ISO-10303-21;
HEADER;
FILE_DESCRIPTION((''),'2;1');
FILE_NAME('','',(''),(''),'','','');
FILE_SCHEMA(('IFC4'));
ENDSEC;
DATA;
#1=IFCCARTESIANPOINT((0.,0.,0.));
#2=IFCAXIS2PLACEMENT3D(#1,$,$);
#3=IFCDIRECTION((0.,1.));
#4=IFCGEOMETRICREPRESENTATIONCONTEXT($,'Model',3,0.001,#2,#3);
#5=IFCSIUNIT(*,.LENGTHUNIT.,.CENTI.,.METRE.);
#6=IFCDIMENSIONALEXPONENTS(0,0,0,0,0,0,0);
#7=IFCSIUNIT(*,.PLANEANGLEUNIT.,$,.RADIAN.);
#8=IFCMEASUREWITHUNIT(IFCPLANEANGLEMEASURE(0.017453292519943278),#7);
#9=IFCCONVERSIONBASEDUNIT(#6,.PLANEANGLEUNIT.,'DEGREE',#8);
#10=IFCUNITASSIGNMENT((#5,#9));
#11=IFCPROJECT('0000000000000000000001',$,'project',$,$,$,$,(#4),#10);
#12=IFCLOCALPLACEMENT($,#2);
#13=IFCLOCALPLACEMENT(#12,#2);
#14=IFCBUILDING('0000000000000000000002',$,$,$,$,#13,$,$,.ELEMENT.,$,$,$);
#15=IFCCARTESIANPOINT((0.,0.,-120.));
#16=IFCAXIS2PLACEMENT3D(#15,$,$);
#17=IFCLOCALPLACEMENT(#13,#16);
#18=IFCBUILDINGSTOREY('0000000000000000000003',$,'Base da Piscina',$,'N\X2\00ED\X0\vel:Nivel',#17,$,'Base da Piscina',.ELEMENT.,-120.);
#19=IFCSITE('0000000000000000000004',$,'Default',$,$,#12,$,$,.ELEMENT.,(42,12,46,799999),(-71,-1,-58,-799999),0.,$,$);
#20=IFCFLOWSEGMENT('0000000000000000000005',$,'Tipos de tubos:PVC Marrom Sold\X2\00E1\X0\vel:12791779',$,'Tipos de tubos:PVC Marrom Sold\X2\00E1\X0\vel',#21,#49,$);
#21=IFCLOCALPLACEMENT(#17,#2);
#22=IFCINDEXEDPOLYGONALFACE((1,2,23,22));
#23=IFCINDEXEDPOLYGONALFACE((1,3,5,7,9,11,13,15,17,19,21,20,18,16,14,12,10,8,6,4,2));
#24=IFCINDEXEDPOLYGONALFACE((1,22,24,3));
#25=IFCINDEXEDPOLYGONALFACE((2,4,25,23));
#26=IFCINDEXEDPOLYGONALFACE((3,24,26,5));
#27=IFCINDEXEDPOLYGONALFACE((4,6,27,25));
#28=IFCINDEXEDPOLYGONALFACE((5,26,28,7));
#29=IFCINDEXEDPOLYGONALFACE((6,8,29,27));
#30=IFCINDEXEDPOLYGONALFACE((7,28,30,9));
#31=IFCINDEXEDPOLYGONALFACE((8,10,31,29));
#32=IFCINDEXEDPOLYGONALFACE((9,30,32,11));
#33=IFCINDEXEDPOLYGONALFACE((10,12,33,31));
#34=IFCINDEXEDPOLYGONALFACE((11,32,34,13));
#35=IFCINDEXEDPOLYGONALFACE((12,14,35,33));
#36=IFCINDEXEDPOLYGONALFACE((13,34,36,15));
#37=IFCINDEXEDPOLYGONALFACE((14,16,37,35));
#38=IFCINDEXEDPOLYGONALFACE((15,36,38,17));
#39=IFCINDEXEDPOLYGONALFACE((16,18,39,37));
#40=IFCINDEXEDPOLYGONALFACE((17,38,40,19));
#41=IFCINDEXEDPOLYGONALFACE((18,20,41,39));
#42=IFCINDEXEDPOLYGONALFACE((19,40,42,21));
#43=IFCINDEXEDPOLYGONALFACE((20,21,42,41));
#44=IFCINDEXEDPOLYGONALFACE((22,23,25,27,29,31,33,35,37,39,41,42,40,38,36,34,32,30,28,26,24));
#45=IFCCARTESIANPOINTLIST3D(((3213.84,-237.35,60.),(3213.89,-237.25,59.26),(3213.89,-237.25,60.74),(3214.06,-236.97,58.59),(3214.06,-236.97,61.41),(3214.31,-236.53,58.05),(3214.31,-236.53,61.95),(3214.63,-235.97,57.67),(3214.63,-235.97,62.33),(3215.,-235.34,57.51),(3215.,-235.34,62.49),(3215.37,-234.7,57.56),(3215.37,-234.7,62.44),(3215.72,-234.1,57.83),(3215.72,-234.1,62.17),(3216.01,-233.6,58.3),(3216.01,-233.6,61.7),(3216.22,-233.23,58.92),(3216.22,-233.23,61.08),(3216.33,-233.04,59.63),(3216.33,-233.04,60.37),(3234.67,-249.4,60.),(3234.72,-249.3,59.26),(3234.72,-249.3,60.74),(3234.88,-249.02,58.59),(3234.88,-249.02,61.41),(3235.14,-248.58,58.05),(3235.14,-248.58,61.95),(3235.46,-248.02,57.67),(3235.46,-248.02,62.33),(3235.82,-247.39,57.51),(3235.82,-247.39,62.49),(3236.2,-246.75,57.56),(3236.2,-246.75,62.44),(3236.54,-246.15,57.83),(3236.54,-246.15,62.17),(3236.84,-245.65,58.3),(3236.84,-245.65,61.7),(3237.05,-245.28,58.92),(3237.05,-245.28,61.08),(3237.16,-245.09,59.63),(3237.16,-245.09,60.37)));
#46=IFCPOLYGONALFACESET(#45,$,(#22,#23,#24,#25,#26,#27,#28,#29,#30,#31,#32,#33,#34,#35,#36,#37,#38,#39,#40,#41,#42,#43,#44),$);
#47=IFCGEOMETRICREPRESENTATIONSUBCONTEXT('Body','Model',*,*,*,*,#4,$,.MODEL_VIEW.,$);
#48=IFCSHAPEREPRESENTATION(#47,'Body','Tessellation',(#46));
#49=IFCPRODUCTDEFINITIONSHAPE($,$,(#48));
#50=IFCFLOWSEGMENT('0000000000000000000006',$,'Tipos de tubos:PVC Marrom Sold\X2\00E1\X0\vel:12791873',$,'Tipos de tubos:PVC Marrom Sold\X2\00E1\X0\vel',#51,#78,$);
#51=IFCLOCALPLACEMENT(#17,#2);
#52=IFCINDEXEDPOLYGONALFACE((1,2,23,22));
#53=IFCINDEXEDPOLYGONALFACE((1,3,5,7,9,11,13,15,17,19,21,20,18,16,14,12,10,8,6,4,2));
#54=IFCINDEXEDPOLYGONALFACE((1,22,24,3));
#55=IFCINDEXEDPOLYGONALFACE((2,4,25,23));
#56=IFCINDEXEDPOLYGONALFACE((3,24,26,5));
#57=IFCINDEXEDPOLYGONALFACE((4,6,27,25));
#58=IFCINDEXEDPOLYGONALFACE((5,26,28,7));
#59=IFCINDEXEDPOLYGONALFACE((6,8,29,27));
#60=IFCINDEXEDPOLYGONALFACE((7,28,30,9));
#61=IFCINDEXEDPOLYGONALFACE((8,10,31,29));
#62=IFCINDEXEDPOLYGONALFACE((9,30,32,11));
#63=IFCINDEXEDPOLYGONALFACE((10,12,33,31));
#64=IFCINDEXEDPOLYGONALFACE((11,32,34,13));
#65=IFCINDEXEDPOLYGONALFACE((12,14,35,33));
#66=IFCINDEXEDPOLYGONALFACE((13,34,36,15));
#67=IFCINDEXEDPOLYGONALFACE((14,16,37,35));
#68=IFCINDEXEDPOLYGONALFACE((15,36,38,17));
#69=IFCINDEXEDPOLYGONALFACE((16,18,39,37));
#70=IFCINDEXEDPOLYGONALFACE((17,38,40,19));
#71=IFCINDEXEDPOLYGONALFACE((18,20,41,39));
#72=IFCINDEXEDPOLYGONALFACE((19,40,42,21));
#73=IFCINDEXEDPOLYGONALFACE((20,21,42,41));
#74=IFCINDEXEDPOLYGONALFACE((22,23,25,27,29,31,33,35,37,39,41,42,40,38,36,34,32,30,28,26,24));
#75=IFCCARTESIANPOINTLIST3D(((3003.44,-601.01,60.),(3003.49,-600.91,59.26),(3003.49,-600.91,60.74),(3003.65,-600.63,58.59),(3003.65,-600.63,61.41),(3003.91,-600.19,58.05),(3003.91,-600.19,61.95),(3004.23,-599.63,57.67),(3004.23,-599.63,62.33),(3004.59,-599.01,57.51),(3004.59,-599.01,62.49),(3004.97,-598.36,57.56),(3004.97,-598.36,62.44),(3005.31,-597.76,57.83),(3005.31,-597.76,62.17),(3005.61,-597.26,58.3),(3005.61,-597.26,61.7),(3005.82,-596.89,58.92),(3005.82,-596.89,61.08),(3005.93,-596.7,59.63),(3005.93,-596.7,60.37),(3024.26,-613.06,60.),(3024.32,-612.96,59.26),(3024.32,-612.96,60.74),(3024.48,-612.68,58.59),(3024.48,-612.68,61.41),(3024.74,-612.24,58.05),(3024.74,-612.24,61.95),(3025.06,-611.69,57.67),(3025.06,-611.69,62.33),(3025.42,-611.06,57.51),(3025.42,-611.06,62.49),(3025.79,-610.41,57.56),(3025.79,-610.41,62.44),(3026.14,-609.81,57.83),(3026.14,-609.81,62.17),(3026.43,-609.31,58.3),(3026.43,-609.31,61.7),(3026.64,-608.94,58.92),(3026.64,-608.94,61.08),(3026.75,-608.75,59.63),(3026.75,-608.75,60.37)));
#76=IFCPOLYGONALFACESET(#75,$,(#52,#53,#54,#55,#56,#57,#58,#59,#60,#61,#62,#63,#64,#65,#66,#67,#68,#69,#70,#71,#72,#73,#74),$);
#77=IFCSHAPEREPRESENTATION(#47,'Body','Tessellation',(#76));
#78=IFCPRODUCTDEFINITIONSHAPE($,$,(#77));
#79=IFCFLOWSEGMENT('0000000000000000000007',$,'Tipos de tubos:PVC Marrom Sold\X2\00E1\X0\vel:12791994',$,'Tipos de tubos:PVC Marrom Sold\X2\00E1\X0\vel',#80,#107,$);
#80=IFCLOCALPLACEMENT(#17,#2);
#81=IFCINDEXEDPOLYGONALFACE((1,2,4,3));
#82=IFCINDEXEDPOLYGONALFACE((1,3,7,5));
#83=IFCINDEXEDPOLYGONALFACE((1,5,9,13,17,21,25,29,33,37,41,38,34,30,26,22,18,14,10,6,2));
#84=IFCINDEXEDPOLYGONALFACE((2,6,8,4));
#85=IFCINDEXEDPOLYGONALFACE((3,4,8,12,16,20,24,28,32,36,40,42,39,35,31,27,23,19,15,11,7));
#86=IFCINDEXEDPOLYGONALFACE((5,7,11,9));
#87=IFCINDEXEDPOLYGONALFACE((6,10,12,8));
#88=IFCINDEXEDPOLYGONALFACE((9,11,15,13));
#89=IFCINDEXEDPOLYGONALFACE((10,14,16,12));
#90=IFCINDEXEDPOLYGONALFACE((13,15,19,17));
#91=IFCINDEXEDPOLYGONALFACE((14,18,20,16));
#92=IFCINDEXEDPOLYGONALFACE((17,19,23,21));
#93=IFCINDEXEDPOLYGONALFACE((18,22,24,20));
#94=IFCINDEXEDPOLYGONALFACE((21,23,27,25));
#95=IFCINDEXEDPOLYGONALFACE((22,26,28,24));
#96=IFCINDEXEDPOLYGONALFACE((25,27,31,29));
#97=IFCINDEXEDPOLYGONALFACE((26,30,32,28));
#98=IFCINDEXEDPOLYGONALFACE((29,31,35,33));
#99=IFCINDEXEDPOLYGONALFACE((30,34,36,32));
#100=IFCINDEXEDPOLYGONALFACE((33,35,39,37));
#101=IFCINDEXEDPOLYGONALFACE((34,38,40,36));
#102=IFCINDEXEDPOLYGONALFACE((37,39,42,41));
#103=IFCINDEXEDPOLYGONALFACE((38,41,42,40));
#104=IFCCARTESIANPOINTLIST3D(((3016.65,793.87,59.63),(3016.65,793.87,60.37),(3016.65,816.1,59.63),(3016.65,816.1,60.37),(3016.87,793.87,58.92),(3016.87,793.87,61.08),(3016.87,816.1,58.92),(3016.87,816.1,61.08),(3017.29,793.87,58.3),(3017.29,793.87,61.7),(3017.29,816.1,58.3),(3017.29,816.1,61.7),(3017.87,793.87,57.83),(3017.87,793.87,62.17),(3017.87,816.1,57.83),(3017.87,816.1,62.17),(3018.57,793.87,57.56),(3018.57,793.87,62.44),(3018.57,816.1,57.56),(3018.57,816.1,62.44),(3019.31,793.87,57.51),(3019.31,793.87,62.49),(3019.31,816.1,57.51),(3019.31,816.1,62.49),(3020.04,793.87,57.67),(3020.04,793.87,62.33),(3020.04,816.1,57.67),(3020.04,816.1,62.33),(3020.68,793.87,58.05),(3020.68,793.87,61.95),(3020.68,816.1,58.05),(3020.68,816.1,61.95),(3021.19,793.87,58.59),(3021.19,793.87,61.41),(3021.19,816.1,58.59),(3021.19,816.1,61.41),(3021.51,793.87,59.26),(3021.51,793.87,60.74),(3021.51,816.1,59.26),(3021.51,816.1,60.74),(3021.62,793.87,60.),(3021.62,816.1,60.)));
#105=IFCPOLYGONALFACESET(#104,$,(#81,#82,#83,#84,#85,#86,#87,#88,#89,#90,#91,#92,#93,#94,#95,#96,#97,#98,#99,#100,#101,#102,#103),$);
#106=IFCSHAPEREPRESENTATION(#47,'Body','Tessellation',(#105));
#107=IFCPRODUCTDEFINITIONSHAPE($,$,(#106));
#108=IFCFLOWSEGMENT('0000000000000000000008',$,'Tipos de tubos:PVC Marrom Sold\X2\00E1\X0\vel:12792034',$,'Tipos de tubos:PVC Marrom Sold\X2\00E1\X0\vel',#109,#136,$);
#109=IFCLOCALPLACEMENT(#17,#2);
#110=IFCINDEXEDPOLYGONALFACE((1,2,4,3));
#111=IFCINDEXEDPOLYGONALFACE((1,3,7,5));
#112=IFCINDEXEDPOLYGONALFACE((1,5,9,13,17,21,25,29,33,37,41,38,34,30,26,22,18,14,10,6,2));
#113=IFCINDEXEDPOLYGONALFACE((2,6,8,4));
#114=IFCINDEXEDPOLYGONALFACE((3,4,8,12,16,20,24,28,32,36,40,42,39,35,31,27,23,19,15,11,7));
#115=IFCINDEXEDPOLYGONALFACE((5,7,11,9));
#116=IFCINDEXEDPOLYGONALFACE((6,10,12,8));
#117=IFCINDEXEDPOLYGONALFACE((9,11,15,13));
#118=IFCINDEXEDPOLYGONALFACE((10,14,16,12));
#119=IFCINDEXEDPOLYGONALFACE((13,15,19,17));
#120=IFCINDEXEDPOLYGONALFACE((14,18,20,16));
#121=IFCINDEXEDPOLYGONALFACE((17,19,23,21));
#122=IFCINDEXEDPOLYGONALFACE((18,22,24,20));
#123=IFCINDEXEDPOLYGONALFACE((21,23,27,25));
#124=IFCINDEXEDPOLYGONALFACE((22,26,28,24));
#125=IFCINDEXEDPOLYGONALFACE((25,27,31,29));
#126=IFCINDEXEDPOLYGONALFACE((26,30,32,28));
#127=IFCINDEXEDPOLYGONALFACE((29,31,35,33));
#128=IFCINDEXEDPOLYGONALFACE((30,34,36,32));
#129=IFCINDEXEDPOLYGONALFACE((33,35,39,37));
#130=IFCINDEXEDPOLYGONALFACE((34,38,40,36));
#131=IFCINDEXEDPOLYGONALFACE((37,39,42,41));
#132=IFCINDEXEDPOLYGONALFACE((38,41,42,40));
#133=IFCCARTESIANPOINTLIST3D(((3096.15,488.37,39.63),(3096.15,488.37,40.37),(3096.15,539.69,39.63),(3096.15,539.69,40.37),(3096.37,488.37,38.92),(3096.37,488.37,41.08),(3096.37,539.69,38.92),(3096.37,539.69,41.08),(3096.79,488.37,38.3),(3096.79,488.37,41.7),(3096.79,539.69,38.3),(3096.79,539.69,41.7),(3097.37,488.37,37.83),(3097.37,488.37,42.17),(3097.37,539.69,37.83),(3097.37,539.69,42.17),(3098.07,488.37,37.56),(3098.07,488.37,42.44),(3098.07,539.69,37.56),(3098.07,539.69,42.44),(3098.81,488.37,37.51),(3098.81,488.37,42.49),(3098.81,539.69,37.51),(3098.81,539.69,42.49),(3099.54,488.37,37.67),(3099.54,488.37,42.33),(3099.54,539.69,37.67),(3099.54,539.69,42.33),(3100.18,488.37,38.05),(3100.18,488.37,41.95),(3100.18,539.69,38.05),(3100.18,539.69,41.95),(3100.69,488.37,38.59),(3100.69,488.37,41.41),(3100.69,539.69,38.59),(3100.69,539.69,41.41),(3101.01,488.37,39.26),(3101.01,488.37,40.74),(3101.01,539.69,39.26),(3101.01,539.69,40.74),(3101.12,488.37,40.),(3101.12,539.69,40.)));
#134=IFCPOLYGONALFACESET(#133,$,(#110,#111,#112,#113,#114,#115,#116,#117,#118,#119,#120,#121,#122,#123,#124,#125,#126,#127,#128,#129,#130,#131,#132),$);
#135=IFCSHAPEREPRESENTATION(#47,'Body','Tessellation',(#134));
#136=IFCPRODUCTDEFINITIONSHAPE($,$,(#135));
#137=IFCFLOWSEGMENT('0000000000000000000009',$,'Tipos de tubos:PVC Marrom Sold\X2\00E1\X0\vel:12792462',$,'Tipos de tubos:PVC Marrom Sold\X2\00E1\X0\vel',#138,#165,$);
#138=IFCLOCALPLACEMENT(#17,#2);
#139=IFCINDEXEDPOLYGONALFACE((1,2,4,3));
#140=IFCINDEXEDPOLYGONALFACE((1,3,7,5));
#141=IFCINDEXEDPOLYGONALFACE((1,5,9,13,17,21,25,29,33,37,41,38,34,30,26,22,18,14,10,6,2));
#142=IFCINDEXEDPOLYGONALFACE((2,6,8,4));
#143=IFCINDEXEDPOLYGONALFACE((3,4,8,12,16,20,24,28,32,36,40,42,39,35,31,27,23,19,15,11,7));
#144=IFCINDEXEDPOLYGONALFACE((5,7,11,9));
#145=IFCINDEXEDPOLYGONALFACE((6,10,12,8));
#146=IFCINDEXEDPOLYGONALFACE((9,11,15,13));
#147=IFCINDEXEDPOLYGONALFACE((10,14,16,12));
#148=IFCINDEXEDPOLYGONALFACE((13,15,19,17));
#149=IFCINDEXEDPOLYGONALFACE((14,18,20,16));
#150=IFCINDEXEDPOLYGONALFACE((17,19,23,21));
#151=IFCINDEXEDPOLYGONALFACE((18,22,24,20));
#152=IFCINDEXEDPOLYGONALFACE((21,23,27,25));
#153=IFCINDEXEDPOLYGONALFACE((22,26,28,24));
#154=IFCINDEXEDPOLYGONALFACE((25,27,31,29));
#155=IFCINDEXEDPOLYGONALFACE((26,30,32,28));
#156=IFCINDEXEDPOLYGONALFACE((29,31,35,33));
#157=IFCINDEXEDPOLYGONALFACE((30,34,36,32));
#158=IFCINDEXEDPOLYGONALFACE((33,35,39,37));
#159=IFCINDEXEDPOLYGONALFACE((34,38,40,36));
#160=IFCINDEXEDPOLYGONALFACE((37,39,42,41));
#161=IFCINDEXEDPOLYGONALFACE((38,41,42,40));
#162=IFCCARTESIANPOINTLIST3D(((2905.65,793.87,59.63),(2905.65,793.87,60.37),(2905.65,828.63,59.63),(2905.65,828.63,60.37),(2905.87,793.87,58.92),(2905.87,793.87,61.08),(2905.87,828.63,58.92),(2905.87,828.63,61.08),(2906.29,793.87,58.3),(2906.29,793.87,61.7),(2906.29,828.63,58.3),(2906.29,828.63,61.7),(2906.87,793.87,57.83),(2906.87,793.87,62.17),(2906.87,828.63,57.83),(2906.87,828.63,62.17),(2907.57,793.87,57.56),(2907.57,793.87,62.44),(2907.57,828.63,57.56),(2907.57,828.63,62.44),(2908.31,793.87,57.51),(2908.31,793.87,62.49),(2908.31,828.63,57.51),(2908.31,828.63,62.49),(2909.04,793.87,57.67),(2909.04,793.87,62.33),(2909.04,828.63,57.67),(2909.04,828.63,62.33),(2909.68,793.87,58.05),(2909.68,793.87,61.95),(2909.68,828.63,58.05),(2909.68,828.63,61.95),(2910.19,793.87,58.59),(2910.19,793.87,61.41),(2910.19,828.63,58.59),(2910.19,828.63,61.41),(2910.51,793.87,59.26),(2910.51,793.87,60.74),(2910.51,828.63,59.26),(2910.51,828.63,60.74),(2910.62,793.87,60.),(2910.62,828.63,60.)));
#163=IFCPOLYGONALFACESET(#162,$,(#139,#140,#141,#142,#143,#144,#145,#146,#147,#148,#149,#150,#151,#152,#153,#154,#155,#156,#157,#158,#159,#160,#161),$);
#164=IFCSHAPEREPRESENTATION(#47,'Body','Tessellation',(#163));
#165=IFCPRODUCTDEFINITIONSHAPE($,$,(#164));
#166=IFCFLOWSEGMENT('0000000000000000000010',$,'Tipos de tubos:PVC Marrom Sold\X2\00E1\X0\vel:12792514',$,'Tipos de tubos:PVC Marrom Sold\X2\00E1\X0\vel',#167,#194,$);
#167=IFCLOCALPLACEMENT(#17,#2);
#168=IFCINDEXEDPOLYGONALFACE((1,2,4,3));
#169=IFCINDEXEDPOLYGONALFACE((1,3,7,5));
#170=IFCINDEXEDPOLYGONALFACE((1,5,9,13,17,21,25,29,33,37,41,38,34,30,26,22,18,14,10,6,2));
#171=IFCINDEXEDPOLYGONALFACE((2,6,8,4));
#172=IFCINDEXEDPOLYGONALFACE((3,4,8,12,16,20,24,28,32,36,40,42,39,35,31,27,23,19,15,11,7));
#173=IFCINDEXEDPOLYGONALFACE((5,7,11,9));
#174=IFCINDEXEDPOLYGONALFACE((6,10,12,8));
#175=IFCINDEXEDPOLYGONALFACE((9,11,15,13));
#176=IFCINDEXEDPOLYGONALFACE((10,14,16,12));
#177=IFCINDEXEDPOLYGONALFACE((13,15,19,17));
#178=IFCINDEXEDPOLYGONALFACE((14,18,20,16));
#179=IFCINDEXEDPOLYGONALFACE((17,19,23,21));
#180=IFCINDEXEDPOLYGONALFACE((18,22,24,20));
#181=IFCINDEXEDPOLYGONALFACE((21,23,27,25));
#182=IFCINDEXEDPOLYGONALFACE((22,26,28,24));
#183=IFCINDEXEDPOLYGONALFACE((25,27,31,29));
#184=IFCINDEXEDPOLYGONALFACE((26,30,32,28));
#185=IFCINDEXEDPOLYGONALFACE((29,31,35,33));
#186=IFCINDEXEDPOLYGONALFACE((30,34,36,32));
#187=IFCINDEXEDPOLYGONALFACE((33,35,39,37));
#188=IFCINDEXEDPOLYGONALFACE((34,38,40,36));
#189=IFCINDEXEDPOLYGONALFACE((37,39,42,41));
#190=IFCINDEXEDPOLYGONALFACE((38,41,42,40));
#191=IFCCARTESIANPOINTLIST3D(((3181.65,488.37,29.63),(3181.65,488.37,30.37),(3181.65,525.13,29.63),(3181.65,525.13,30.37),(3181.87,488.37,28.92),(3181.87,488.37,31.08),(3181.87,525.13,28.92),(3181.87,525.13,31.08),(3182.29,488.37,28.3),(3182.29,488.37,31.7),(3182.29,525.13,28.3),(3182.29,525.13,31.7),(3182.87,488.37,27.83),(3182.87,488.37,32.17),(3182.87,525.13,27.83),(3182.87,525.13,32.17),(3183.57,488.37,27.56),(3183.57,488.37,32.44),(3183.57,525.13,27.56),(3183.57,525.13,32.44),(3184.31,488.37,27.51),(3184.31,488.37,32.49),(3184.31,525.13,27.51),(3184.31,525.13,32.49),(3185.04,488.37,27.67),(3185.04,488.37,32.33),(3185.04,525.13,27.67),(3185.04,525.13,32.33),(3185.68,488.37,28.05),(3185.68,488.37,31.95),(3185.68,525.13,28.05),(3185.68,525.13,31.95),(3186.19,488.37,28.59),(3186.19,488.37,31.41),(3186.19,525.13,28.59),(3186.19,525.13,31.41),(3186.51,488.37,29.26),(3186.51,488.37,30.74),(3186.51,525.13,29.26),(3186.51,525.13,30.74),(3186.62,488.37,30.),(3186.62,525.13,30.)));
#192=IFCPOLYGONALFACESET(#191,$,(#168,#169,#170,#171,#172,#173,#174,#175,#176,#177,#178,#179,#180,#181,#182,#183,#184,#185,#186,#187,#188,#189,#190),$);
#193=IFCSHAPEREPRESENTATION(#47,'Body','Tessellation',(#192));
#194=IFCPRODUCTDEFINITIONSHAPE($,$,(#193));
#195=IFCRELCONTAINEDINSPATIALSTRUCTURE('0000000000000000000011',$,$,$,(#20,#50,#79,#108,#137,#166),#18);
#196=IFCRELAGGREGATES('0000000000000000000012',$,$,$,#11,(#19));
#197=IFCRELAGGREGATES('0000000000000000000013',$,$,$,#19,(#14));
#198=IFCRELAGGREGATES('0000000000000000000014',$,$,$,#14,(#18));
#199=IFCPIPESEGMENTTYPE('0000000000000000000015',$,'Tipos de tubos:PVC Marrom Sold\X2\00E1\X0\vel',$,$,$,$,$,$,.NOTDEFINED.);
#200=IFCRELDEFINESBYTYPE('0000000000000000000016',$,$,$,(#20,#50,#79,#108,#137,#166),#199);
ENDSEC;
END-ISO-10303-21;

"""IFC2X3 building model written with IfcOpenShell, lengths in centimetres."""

from ifc_helpers import new_model, entity, si_unit, converted_unit, direction, frame, frame_2d, origin, origin_2d_with_axis, place, context, subcontext, project, spatial, circle, extrude, type_object, element, save


model = new_model("IFC2X3")

# Units and contexts
model_context = context("Model", 3, precision=0.001, world=origin(), true_north=direction((0.0, 1.0)))
body_context = subcontext(model_context, "Body", "Model", "MODEL_VIEW")
ifc_project = project(units=[si_unit("LENGTHUNIT", "METRE", prefix="CENTI"), converted_unit("PLANEANGLEUNIT", "DEGREE", entity("IfcPlaneAngleMeasure", 0.017453292519943278), si_unit("PLANEANGLEUNIT", "RADIAN"), dimensions=[0, 0, 0, 0, 0, 0, 0])], contexts=[model_context])

# Site, building, storey
site_placement = place(None, origin())
site = spatial("IfcSite", under=ifc_project, at=site_placement, Name="Default", CompositionType="ELEMENT", RefLatitude=(42, 12, 46, 799999), RefLongitude=(-71, -1, -58, -799999), RefElevation=0.0)
building_placement = place(site_placement, origin())
building = spatial("IfcBuilding", under=site, at=building_placement, CompositionType="ELEMENT")
storey_placement = place(building_placement, frame((0.0, 0.0, -120.0)))
storey = spatial("IfcBuildingStorey", under=building, at=storey_placement, Name="Base da Piscina", ObjectType="Nível:Nivel", LongName="Base da Piscina", CompositionType="ELEMENT", Elevation=-120.0)

# Flow segments
pipe_segment_type = type_object("IfcPipeSegmentType", Name="Tipos de tubos:PVC Marrom Soldável", PredefinedType="NOTDEFINED")
flow_segment_1_placement = place(storey_placement, origin())
element("IfcFlowSegment", 1, at=flow_segment_1_placement, inside=storey, type_object=pipe_segment_type, Name="Tipos de tubos:PVC Marrom Soldável:12791779", ObjectType="Tipos de tubos:PVC Marrom Soldável", context=body_context, shape_type="SweptSolid", body=[
    extrude(circle(Radius=2.5, at=frame_2d((0.0, 0.0), x_axis=(1.0, 0.0))), frame((3215.09, -235.18, 60.0), z_axis=(0.865569, -0.50079, 0.0), x_axis=(-0.50079, -0.865569, 0.0)), (0.0, 0.0, 1.0), 24.06),
])
flow_segment_2_placement = place(storey_placement, origin())
element("IfcFlowSegment", 2, at=flow_segment_2_placement, inside=storey, type_object=pipe_segment_type, Name="Tipos de tubos:PVC Marrom Soldável:12791873", ObjectType="Tipos de tubos:PVC Marrom Soldável", context=body_context, shape_type="SweptSolid", body=[
    extrude(circle(Radius=2.5, at=origin_2d_with_axis()), frame((3004.69, -598.84, 60.0), z_axis=(0.865569, -0.50079, 0.0), x_axis=(-0.50079, -0.865569, 0.0)), (0.0, 0.0, 1.0), 24.06),
])
flow_segment_3_placement = place(storey_placement, origin())
element("IfcFlowSegment", 3, at=flow_segment_3_placement, inside=storey, type_object=pipe_segment_type, Name="Tipos de tubos:PVC Marrom Soldável:12791994", ObjectType="Tipos de tubos:PVC Marrom Soldável", context=body_context, shape_type="SweptSolid", body=[
    extrude(circle(Radius=2.5, at=origin_2d_with_axis()), frame((3019.12, 793.87, 60.0), z_axis=(0.0, 1.0, 0.0), x_axis=(1.0, 0.0, 0.0)), (0.0, 0.0, 1.0), 22.23),
])
flow_segment_4_placement = place(storey_placement, origin())
element("IfcFlowSegment", 4, at=flow_segment_4_placement, inside=storey, type_object=pipe_segment_type, Name="Tipos de tubos:PVC Marrom Soldável:12792034", ObjectType="Tipos de tubos:PVC Marrom Soldável", context=body_context, shape_type="SweptSolid", body=[
    extrude(circle(Radius=2.5, at=origin_2d_with_axis()), frame((3098.62, 488.37, 40.0), z_axis=(0.0, 1.0, 0.0), x_axis=(1.0, 0.0, 0.0)), (0.0, 0.0, 1.0), 51.32),
])
flow_segment_5_placement = place(storey_placement, origin())
element("IfcFlowSegment", 5, at=flow_segment_5_placement, inside=storey, type_object=pipe_segment_type, Name="Tipos de tubos:PVC Marrom Soldável:12792462", ObjectType="Tipos de tubos:PVC Marrom Soldável", context=body_context, shape_type="SweptSolid", body=[
    extrude(circle(Radius=2.5, at=origin_2d_with_axis()), frame((2908.12, 793.87, 60.0), z_axis=(0.0, 1.0, 0.0), x_axis=(1.0, 0.0, 0.0)), (0.0, 0.0, 1.0), 34.76),
])
flow_segment_6_placement = place(storey_placement, origin())
element("IfcFlowSegment", 6, at=flow_segment_6_placement, inside=storey, type_object=pipe_segment_type, Name="Tipos de tubos:PVC Marrom Soldável:12792514", ObjectType="Tipos de tubos:PVC Marrom Soldável", context=body_context, shape_type="SweptSolid", body=[
    extrude(circle(Radius=2.5, at=origin_2d_with_axis()), frame((3184.12, 488.37, 30.0), z_axis=(0.0, 1.0, 0.0), x_axis=(1.0, 0.0, 0.0)), (0.0, 0.0, 1.0), 36.76),
])

save(model, "model.ifc")
